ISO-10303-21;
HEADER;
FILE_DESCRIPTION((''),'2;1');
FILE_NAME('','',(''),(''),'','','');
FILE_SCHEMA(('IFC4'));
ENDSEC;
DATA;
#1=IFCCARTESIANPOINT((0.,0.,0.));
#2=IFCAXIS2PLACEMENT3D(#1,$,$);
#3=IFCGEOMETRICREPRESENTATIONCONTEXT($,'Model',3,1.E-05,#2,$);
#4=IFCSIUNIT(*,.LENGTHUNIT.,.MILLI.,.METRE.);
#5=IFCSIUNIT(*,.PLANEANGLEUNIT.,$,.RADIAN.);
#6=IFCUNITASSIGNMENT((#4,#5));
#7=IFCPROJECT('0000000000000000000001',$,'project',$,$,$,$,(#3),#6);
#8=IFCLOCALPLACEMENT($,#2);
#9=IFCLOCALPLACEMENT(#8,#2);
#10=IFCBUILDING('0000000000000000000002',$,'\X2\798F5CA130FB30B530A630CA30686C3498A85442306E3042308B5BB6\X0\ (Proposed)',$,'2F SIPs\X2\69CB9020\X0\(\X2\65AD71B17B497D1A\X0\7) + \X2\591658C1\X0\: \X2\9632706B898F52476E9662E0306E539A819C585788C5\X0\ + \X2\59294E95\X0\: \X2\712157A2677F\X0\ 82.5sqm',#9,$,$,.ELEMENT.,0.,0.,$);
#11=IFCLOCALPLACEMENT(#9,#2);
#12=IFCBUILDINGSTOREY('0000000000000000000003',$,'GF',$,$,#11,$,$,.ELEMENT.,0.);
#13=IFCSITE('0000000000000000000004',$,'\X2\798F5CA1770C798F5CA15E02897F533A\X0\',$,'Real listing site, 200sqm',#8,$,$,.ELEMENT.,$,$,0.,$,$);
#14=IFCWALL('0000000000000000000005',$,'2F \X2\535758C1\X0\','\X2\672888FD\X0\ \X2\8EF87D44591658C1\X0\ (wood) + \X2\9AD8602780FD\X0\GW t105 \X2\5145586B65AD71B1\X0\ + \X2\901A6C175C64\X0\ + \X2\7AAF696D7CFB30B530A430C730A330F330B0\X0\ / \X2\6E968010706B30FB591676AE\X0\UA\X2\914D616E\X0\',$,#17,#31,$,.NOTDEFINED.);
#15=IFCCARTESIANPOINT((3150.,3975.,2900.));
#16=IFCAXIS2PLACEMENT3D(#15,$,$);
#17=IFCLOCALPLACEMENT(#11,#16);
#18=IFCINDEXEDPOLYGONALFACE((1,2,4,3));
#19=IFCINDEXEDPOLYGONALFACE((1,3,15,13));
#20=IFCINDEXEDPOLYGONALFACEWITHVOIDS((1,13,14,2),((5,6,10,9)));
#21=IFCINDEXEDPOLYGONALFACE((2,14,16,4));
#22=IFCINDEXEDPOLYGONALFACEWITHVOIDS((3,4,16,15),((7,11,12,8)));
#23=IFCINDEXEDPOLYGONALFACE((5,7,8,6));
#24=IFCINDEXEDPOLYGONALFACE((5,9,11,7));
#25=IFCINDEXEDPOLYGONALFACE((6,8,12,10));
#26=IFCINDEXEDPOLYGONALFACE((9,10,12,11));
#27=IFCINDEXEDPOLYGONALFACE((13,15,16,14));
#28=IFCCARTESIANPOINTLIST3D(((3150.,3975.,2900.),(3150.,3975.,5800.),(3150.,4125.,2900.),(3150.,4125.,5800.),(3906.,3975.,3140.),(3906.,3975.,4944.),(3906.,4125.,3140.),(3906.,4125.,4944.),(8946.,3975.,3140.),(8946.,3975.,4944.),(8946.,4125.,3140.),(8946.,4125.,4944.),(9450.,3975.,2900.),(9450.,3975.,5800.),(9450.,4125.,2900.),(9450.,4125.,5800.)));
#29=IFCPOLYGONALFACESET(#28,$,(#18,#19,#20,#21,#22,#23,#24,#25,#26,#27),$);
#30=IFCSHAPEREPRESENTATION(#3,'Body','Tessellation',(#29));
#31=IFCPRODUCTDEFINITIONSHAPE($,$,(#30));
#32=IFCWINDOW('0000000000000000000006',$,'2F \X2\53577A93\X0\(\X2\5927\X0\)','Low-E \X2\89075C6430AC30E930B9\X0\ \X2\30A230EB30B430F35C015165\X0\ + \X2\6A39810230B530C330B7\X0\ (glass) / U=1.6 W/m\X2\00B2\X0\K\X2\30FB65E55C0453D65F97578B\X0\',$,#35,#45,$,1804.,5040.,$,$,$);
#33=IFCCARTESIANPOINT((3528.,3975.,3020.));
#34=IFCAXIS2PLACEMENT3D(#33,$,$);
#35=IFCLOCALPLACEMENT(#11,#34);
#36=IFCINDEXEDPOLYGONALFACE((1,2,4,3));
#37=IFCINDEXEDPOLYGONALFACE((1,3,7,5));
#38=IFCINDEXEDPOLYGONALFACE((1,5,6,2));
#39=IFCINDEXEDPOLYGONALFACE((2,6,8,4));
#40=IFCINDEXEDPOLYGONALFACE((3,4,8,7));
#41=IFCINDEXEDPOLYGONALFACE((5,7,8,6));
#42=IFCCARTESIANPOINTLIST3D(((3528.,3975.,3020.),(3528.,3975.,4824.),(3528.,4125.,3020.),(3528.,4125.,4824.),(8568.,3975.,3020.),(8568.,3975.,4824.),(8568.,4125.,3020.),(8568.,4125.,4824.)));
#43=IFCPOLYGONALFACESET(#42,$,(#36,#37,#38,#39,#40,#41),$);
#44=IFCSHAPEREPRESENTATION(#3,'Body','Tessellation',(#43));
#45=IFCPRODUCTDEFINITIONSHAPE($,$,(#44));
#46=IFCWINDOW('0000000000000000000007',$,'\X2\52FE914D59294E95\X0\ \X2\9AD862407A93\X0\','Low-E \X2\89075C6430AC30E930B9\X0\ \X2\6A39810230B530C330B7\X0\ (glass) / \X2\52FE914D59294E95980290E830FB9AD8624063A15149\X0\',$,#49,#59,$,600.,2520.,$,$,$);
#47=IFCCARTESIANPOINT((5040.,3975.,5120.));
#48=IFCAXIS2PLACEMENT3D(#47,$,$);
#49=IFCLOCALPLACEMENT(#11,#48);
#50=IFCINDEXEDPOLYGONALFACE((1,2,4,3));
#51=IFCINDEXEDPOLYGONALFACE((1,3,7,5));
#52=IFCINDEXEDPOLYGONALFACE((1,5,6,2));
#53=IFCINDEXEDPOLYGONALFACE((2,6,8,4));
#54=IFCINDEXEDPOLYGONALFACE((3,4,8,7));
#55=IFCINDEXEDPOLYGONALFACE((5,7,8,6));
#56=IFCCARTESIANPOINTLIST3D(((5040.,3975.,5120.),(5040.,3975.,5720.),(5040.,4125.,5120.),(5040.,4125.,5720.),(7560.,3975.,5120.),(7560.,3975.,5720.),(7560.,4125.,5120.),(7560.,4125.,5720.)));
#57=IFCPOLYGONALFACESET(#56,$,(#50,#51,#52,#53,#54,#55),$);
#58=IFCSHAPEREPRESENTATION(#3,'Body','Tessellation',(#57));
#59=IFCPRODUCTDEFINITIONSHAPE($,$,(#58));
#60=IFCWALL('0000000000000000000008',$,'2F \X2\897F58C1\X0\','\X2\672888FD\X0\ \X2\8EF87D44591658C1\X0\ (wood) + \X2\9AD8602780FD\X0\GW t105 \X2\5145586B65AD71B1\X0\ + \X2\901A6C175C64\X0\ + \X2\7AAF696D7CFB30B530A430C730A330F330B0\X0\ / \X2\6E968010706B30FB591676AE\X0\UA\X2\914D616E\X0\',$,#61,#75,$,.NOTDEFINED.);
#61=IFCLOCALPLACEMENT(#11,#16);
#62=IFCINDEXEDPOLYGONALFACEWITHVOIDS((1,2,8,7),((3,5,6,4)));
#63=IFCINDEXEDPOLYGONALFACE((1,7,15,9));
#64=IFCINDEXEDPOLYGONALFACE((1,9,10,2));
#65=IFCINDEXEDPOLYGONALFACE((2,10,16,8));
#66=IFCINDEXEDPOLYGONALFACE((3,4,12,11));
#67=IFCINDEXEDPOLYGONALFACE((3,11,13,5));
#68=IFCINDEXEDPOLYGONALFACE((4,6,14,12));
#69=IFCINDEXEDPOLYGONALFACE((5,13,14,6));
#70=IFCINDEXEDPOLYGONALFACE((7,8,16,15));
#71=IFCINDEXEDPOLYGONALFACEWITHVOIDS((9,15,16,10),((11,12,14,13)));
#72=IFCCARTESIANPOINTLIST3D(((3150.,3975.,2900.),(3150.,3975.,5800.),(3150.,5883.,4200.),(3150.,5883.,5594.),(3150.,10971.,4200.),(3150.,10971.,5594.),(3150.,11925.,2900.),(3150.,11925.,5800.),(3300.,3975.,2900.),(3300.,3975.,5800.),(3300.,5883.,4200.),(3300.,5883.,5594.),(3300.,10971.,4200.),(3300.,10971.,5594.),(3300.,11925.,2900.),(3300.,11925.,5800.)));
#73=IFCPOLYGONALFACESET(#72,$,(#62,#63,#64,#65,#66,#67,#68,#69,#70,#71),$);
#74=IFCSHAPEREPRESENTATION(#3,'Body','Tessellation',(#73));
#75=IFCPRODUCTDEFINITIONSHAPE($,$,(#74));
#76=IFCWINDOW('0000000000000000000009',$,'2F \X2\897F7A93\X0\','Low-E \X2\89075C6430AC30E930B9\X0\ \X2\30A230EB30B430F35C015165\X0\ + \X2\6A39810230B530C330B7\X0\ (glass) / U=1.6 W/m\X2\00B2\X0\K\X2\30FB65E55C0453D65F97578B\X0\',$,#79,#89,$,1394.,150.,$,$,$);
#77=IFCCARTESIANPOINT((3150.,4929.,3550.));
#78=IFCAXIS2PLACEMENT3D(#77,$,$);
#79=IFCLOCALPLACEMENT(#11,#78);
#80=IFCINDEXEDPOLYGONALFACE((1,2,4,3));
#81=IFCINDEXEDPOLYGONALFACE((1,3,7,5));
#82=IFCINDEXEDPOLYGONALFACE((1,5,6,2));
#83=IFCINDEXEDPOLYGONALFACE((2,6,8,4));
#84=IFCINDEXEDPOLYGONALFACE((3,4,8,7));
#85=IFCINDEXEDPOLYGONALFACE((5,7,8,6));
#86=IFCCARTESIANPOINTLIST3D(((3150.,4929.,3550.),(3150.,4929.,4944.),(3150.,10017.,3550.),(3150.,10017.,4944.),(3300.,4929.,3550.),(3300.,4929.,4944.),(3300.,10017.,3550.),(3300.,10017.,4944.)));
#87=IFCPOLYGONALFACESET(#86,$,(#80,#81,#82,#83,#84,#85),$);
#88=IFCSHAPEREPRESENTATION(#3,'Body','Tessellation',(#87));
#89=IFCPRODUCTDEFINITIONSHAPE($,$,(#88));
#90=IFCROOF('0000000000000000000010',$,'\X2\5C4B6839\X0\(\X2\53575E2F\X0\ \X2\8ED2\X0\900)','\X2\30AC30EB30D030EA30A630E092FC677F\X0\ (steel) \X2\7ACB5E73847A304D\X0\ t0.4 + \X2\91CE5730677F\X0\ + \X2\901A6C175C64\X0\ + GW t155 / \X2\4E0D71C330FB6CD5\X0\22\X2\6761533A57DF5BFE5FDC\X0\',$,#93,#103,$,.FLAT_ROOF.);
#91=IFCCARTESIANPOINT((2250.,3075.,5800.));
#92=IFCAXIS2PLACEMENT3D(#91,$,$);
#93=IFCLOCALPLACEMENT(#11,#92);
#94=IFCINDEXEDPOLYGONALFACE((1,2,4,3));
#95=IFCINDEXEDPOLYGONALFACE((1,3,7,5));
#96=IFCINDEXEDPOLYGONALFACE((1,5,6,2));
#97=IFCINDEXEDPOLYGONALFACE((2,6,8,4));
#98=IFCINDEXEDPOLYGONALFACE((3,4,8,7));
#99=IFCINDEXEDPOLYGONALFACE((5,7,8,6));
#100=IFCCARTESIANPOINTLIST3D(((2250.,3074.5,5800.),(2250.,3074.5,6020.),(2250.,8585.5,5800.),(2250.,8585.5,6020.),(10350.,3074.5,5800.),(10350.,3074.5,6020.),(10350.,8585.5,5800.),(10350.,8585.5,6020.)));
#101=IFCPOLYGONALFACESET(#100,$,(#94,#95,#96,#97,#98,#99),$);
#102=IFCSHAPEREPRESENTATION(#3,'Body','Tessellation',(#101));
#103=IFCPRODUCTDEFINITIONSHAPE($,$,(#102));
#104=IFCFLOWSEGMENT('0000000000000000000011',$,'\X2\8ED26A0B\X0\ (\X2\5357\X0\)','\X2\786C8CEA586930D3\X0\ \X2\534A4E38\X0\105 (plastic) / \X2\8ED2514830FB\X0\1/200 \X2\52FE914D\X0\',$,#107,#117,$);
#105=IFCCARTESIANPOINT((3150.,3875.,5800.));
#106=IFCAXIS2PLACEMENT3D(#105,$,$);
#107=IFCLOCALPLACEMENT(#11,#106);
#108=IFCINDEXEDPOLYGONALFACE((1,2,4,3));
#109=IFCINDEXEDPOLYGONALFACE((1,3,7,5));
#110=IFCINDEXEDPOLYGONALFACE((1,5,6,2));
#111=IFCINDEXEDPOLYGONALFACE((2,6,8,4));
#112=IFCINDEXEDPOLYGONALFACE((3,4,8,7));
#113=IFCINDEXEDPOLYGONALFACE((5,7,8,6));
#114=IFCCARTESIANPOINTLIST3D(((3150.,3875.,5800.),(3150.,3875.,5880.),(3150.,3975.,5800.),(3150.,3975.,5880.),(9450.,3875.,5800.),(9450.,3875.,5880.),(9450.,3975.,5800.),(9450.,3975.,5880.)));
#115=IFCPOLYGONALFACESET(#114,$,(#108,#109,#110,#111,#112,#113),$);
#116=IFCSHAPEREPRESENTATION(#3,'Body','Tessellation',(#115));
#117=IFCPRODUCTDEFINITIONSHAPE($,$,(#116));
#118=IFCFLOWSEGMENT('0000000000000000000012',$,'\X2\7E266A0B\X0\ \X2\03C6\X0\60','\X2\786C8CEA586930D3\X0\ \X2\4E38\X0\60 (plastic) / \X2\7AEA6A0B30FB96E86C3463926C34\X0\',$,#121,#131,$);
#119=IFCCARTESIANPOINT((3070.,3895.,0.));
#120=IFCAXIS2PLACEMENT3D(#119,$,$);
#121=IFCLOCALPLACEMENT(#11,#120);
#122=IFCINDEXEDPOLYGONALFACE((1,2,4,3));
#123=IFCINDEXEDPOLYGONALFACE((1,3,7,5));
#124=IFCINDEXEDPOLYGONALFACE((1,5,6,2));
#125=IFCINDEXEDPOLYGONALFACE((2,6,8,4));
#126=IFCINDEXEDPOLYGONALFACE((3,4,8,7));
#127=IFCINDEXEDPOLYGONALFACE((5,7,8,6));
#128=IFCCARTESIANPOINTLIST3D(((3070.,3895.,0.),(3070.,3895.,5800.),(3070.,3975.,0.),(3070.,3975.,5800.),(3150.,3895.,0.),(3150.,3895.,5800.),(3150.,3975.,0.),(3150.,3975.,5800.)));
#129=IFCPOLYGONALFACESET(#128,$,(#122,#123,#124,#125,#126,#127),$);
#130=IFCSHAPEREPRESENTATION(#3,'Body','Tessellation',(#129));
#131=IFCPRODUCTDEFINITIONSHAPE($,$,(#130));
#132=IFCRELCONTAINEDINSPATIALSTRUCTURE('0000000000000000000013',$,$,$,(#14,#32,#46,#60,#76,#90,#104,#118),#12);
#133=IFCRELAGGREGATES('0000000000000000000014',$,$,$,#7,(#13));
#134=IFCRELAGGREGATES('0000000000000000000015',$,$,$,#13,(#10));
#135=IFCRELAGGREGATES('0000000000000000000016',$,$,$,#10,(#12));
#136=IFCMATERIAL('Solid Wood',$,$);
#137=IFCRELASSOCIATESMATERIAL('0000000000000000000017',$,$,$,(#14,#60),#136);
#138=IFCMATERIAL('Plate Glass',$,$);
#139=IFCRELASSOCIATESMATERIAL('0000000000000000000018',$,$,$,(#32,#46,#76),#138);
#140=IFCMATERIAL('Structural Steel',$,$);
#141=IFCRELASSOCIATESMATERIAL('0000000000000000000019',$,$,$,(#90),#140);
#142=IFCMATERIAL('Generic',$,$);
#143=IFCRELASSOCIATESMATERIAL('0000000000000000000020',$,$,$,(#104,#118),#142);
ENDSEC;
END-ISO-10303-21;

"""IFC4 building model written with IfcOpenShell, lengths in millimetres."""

from ifc_helpers import new_model, si_unit, frame, frame_2d, origin, place, context, project, spatial, rectangle, extrude, material, element, fill, save


model = new_model("IFC4")

# Units and contexts
model_context = context("Model", 3, precision=1e-05, world=origin())
ifc_project = project(units=[si_unit("LENGTHUNIT", "METRE", prefix="MILLI"), si_unit("PLANEANGLEUNIT", "RADIAN")], contexts=[model_context])

# Site, building, storey
site_placement = place(None, origin())
site = spatial("IfcSite", under=ifc_project, at=site_placement, Name="福岡県福岡市西区", ObjectType="Real listing site, 200sqm", CompositionType="ELEMENT", RefElevation=0.0)
building_placement = place(site_placement, origin())
building = spatial("IfcBuilding", under=site, at=building_placement, Name="福岡・サウナと水風呂のある家 (Proposed)", ObjectType="2F SIPs構造(断熱等級7) + 外壁: 防火規則準拠の厚膜塗装 + 天井: 無垢板 82.5sqm", CompositionType="ELEMENT", ElevationOfRefHeight=0.0, ElevationOfTerrain=0.0)
storey_placement = place(building_placement, origin())
storey = spatial("IfcBuildingStorey", under=building, at=storey_placement, Name="GF", CompositionType="ELEMENT", Elevation=0.0)

# Shared definitions
ifc_material_1 = material(Name="Solid Wood")

# Shared definitions
ifc_material_2 = material(Name="Plate Glass")

# Wall, openings, windows
wall_1_placement = place(storey_placement, frame((3150.0, 3975.0, 2900.0)))
wall_1 = element("IfcWall", 1, at=wall_1_placement, inside=storey, material=ifc_material_1, Name="2F 南壁", Description="木製 軸組外壁 (wood) + 高性能GW t105 充填断熱 + 通気層 + 窯業系サイディング / 準耐火・外皮UA配慮", PredefinedType="NOTDEFINED", context=model_context, shape_type="SweptSolid", body=[
    extrude(rectangle(XDim=6300.0, YDim=150.0, at=frame_2d((3150.0, 75.0))), frame((3150.0, 3975.0, 2900.0)), (0.0, 0.0, 1.0), 2900.0),
])
opening_1_placement = place(storey_placement, frame((3528.0, 3975.0, 3020.0)))
opening_1 = element("IfcOpeningElement", 2, at=opening_1_placement, cuts=wall_1, PredefinedType="NOTDEFINED", context=model_context, shape_type="SweptSolid", body=[
    extrude(rectangle(XDim=5040.0, YDim=150.0, at=frame_2d((2520.0, 75.0))), frame((3528.0, 3975.0, 3020.0)), (0.0, 0.0, 1.0), 1804.0),
])
opening_2_placement = place(storey_placement, frame((5040.0, 3975.0, 5120.0)))
opening_2 = element("IfcOpeningElement", 3, at=opening_2_placement, cuts=wall_1, PredefinedType="NOTDEFINED", context=model_context, shape_type="SweptSolid", body=[
    extrude(rectangle(XDim=2520.0, YDim=150.0, at=frame_2d((1260.0, 75.0))), frame((5040.0, 3975.0, 5120.0)), (0.0, 0.0, 1.0), 600.0),
])
window_1_placement = place(storey_placement, frame((3528.0, 3975.0, 3020.0)))
window_1 = element("IfcWindow", 4, at=window_1_placement, inside=storey, material=ifc_material_2, Name="2F 南窓(大)", Description="Low-E 複層ガラス アルゴン封入 + 樹脂サッシ (glass) / U=1.6 W/m²K・日射取得型", OverallHeight=1804.0, OverallWidth=5040.0, context=model_context, shape_type="SweptSolid", body=[
    extrude(rectangle(XDim=5040.0, YDim=150.0, at=frame_2d((2520.0, 75.0))), frame((3528.0, 3975.0, 3020.0)), (0.0, 0.0, 1.0), 1804.0),
])
fill(opening_1, window_1)
window_2_placement = place(storey_placement, frame((5040.0, 3975.0, 5120.0)))
window_2 = element("IfcWindow", 5, at=window_2_placement, inside=storey, material=ifc_material_2, Name="勾配天井 高所窓", Description="Low-E 複層ガラス 樹脂サッシ (glass) / 勾配天井頂部・高所採光", OverallHeight=600.0, OverallWidth=2520.0, context=model_context, shape_type="SweptSolid", body=[
    extrude(rectangle(XDim=2520.0, YDim=150.0, at=frame_2d((1260.0, 75.0))), frame((5040.0, 3975.0, 5120.0)), (0.0, 0.0, 1.0), 600.0),
])
fill(opening_2, window_2)

# Wall, opening, window
wall_2_placement = place(storey_placement, frame((3150.0, 3975.0, 2900.0)))
wall_2 = element("IfcWall", 6, at=wall_2_placement, inside=storey, material=ifc_material_1, Name="2F 西壁", Description="木製 軸組外壁 (wood) + 高性能GW t105 充填断熱 + 通気層 + 窯業系サイディング / 準耐火・外皮UA配慮", PredefinedType="NOTDEFINED", context=model_context, shape_type="SweptSolid", body=[
    extrude(rectangle(XDim=150.0, YDim=7950.0, at=frame_2d((75.0, 3975.0))), frame((3150.0, 3975.0, 2900.0)), (0.0, 0.0, 1.0), 2900.0),
])
opening_3_placement = place(storey_placement, frame((3150.0, 4929.0, 3550.0)))
opening_3 = element("IfcOpeningElement", 7, at=opening_3_placement, cuts=wall_2, PredefinedType="NOTDEFINED", context=model_context, shape_type="SweptSolid", body=[
    extrude(rectangle(XDim=150.0, YDim=5088.0, at=frame_2d((75.0, 2544.0))), frame((3150.0, 4929.0, 3550.0)), (0.0, 0.0, 1.0), 1394.0),
])
window_3_placement = place(storey_placement, frame((3150.0, 4929.0, 3550.0)))
window_3 = element("IfcWindow", 8, at=window_3_placement, inside=storey, material=ifc_material_2, Name="2F 西窓", Description="Low-E 複層ガラス アルゴン封入 + 樹脂サッシ (glass) / U=1.6 W/m²K・日射取得型", OverallHeight=1394.0, OverallWidth=150.0, context=model_context, shape_type="SweptSolid", body=[
    extrude(rectangle(XDim=150.0, YDim=5088.0, at=frame_2d((75.0, 2544.0))), frame((3150.0, 4929.0, 3550.0)), (0.0, 0.0, 1.0), 1394.0),
])
fill(opening_3, window_3)

# Roof
ifc_material_3 = material(Name="Structural Steel")
for number, where, name in (
    (9, (2250.0, 3075.0, 5800.0), "屋根(南帯 軒900)"),
):
    element("IfcRoof", number, at=place(storey_placement, frame(where)), inside=storey, material=ifc_material_3, Name=name, Description="ガルバリウム鋼板 (steel) 立平葺き t0.4 + 野地板 + 通気層 + GW t155 / 不燃・法22条区域対応", PredefinedType="FLAT_ROOF", context=model_context, shape_type="SweptSolid", body=[
        extrude(rectangle(XDim=8100.0, YDim=5511.0, at=frame_2d((4050.0, 2755.0))), frame((2250.0, 3075.0, 5800.0)), (0.0, 0.0, 1.0), 220.0),
    ])

# Flow segments
ifc_material_4 = material(Name="Generic")
flow_segment_1_placement = place(storey_placement, frame((3150.0, 3875.0, 5800.0)))
element("IfcFlowSegment", 10, at=flow_segment_1_placement, inside=storey, material=ifc_material_4, Name="軒樋 (南)", Description="硬質塩ビ 半丸105 (plastic) / 軒先・1/200 勾配", context=model_context, shape_type="SweptSolid", body=[
    extrude(rectangle(XDim=6300.0, YDim=100.0, at=frame_2d((3150.0, 50.0))), frame((3150.0, 3875.0, 5800.0)), (0.0, 0.0, 1.0), 80.0),
])
flow_segment_2_placement = place(storey_placement, frame((3070.0, 3895.0, 0.0)))
element("IfcFlowSegment", 11, at=flow_segment_2_placement, inside=storey, material=ifc_material_4, Name="縦樋 φ60", Description="硬質塩ビ 丸60 (plastic) / 竪樋・雨水排水", context=model_context, shape_type="SweptSolid", body=[
    extrude(rectangle(XDim=80.0, YDim=80.0, at=frame_2d((40.0, 40.0))), frame((3070.0, 3895.0, 0.0)), (0.0, 0.0, 1.0), 5800.0),
])

save(model, "model.ifc")
